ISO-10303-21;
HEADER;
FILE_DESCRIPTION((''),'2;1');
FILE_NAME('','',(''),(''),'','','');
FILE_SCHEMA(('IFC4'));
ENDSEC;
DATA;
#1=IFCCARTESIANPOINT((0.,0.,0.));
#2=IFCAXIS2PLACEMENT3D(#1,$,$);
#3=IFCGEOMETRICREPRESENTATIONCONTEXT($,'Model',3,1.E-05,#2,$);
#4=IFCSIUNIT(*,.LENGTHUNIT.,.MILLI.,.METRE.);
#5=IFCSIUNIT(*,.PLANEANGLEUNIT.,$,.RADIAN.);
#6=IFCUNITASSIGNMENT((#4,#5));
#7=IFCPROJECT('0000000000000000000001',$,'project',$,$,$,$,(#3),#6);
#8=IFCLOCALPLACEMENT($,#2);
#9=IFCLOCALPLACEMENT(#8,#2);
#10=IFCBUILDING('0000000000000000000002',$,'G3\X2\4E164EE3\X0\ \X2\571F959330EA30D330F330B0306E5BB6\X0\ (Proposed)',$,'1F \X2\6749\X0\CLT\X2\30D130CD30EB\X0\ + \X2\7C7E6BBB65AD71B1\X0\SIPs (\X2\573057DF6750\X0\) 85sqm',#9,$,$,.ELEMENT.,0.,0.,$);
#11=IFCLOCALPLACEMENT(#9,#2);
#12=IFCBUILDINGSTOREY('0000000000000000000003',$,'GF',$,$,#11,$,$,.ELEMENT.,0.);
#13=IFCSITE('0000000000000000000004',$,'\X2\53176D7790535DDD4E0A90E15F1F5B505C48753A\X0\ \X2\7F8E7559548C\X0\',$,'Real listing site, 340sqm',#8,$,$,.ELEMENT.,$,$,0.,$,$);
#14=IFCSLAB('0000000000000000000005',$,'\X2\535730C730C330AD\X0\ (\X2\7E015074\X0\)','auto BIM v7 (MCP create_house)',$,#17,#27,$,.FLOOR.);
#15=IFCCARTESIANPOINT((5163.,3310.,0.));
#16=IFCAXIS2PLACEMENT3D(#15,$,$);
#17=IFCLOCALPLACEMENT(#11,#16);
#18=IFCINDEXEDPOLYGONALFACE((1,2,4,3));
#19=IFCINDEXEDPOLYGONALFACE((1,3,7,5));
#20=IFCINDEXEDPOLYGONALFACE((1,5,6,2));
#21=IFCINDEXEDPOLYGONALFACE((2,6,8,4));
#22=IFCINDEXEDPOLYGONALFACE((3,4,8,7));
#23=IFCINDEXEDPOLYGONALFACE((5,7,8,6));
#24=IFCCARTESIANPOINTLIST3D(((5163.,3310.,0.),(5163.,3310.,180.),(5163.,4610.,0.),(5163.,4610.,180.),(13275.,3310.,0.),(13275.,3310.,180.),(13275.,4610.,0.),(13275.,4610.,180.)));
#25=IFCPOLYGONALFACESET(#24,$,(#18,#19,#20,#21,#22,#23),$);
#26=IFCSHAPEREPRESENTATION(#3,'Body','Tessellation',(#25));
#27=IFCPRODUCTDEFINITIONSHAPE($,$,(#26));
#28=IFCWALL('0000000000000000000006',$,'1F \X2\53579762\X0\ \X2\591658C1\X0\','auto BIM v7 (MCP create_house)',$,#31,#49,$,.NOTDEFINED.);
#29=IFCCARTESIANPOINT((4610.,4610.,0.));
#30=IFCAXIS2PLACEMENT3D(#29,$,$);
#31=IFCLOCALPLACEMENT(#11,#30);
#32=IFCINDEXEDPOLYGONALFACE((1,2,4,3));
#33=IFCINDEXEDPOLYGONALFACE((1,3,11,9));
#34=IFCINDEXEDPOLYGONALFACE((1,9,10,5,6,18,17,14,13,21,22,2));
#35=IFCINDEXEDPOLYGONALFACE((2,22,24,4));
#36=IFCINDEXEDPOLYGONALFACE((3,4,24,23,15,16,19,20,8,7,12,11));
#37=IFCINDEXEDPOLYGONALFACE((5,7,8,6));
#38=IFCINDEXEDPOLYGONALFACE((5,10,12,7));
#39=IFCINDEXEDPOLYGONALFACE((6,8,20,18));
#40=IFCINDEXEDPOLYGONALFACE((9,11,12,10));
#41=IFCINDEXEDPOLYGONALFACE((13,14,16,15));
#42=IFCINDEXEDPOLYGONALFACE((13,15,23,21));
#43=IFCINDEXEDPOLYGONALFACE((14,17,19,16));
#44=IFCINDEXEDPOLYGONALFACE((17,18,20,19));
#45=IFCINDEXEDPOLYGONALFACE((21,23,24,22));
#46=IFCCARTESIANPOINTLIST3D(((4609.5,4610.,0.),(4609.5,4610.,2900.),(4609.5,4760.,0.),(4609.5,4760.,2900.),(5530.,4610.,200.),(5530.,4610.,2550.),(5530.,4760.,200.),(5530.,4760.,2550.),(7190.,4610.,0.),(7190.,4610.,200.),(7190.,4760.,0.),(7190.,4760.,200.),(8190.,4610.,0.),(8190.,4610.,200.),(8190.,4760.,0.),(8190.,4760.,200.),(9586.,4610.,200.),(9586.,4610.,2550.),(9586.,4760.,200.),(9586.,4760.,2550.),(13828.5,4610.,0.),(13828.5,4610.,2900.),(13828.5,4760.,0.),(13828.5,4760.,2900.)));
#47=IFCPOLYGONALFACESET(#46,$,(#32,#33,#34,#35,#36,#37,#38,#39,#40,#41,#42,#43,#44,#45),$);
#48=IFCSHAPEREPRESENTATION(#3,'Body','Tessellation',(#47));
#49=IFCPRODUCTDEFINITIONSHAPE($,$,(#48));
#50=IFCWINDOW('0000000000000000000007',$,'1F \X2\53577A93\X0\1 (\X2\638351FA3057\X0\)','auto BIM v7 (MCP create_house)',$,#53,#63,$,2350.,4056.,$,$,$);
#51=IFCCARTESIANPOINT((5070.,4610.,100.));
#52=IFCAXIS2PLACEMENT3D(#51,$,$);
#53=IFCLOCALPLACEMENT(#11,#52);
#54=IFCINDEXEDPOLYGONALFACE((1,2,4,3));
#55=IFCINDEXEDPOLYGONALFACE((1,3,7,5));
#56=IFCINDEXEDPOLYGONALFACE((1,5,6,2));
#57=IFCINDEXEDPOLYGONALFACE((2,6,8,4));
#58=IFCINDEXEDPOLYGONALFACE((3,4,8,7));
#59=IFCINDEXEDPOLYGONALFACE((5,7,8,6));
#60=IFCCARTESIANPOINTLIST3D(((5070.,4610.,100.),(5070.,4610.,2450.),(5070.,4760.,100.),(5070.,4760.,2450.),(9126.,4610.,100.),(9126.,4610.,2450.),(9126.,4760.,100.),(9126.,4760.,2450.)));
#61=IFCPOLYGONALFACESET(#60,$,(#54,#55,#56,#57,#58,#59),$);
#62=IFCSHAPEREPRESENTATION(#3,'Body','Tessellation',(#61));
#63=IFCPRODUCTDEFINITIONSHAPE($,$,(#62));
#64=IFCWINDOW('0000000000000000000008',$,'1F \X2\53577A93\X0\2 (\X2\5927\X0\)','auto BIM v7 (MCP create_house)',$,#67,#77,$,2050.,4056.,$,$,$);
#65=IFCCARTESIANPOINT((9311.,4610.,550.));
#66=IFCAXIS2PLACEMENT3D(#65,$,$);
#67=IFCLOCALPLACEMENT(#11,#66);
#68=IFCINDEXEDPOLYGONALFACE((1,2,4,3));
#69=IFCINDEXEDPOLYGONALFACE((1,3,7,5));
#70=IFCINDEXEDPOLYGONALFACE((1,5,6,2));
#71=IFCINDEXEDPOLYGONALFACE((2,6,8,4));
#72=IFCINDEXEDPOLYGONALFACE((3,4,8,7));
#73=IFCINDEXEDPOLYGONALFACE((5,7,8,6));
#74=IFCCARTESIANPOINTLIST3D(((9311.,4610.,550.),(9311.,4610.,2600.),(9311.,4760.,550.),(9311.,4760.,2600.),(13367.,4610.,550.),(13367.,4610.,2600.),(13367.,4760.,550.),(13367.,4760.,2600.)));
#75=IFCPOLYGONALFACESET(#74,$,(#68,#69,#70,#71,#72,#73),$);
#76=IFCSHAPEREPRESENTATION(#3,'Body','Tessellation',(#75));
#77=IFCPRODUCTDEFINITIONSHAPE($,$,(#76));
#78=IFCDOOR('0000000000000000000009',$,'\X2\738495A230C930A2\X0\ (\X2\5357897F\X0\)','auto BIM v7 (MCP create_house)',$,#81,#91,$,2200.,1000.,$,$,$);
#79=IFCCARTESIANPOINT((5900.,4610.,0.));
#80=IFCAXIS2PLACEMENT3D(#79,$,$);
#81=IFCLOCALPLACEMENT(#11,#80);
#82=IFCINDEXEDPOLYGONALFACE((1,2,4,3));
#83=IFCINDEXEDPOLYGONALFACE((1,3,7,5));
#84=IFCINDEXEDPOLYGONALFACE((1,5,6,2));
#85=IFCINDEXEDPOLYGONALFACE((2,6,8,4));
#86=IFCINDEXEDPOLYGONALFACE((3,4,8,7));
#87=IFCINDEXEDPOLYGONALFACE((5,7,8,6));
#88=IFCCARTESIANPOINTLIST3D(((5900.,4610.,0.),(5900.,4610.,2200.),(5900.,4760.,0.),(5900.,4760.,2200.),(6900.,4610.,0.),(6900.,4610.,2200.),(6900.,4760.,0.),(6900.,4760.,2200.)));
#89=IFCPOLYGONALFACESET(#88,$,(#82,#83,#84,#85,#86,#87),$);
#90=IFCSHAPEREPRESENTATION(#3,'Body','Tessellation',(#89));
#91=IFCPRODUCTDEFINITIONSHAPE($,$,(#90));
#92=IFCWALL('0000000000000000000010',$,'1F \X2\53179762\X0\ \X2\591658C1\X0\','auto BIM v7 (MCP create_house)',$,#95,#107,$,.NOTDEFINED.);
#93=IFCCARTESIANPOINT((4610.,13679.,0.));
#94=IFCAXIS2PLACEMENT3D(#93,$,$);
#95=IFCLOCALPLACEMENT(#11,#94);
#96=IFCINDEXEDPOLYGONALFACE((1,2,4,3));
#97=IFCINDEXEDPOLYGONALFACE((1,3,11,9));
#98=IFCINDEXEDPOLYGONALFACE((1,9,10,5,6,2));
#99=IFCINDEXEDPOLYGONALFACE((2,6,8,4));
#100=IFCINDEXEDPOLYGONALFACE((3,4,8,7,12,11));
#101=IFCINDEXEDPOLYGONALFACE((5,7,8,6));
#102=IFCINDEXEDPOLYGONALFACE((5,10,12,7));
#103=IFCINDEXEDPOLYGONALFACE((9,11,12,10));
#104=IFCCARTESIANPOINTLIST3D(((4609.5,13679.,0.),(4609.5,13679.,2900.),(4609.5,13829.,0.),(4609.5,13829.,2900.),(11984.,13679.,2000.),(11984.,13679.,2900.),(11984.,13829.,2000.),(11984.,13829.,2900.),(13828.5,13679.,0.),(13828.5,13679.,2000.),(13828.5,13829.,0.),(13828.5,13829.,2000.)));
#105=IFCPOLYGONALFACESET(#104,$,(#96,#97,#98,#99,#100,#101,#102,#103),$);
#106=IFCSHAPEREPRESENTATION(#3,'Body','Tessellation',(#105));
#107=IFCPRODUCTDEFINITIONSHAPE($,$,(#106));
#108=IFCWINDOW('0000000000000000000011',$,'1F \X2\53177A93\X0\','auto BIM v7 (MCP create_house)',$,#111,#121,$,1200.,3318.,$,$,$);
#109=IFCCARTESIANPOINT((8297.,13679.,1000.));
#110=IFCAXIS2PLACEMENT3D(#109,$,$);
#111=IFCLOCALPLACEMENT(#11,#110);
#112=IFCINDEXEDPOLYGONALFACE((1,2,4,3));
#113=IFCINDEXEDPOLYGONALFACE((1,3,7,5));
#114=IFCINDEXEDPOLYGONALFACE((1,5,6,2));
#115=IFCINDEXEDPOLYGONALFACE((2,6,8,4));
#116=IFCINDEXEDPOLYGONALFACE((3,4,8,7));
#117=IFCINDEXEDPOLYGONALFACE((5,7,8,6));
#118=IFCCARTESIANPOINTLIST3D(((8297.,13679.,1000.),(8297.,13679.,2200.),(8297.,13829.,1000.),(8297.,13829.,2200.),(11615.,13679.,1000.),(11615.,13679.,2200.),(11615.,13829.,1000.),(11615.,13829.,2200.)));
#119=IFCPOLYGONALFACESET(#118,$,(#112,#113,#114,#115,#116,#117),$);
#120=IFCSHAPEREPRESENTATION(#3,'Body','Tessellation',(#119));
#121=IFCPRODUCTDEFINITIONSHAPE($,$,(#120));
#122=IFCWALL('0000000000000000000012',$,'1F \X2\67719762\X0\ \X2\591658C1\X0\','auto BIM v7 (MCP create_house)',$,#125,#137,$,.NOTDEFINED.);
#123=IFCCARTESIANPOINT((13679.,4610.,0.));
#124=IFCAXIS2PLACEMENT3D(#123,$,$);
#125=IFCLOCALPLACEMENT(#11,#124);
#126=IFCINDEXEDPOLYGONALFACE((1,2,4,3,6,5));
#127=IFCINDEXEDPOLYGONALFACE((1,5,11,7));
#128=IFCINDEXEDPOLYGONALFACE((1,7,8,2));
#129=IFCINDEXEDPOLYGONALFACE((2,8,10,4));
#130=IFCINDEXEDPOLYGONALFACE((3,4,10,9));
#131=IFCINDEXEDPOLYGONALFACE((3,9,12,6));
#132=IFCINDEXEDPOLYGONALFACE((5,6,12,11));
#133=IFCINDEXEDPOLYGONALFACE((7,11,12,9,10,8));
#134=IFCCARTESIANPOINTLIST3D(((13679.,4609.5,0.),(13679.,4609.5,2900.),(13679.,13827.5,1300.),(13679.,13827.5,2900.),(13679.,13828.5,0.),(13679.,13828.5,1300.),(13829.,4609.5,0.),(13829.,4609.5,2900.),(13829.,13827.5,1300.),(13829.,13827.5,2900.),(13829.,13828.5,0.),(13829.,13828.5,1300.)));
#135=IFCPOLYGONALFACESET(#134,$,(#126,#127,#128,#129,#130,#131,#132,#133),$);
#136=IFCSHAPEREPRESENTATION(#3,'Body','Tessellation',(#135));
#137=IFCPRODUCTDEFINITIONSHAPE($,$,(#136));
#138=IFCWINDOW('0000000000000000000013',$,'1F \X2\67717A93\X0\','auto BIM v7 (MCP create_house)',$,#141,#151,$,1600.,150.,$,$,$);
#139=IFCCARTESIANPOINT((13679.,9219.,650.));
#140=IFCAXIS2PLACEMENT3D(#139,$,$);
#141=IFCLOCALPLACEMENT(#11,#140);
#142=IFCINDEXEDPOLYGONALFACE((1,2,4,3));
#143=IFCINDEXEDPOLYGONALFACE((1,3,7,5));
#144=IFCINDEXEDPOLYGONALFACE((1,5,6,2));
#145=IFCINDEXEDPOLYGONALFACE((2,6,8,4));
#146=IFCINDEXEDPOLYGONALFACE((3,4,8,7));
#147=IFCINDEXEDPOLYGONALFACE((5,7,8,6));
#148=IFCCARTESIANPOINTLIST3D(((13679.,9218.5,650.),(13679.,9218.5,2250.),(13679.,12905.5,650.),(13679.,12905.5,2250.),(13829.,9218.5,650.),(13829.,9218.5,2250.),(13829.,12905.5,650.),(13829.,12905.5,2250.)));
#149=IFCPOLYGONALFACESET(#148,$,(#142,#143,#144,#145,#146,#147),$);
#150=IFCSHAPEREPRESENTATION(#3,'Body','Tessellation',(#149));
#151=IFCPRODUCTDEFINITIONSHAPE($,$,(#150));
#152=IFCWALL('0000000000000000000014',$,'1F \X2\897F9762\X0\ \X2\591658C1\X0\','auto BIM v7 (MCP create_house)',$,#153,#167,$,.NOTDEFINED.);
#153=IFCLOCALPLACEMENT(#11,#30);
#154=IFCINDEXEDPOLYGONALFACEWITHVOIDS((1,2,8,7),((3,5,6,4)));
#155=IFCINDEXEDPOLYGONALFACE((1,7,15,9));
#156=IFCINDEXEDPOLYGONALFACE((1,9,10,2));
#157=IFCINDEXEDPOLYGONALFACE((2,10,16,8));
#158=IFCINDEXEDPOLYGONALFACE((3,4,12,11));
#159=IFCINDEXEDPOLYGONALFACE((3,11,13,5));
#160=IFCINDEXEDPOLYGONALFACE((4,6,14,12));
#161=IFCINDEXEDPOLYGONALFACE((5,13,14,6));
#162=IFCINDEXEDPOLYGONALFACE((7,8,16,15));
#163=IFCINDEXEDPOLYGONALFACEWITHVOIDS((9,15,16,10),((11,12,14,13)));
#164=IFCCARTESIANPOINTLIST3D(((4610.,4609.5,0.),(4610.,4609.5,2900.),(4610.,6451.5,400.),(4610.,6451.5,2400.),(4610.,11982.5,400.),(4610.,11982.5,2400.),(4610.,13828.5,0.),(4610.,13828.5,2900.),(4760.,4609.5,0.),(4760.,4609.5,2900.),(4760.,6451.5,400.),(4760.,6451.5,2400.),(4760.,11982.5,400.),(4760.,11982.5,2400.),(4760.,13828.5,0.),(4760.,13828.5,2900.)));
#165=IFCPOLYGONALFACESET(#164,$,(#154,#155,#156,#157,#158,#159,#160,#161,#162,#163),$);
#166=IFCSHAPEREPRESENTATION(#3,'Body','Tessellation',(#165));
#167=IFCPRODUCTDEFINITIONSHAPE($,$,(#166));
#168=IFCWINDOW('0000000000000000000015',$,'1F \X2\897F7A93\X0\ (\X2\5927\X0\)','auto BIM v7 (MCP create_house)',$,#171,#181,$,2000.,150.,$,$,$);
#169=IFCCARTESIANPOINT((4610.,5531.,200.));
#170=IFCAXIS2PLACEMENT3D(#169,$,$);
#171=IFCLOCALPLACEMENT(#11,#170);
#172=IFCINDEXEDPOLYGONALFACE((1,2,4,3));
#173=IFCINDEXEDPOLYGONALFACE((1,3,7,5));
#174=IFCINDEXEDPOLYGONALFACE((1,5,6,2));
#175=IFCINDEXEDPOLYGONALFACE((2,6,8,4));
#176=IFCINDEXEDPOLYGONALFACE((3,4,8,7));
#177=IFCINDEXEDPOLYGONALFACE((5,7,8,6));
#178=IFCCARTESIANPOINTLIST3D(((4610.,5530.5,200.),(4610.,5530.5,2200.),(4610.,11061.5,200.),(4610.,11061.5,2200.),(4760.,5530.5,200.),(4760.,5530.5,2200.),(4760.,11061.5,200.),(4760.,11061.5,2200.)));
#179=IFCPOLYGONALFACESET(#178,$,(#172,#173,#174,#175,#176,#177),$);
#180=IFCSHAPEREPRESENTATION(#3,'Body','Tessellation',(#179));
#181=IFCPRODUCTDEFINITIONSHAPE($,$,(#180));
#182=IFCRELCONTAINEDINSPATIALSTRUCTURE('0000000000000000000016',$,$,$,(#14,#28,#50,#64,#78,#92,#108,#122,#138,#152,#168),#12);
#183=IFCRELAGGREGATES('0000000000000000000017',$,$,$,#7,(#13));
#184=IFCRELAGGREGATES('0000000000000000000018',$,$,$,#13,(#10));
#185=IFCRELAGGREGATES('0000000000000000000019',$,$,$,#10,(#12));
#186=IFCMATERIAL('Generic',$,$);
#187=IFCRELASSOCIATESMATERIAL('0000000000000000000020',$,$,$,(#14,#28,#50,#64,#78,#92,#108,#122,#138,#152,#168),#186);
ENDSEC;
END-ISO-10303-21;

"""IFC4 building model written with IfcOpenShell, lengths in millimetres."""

from ifc_helpers import new_model, si_unit, frame, frame_2d, origin, place, context, project, spatial, rectangle, extrude, material, element, fill, save


model = new_model("IFC4")

# Units and contexts
model_context = context("Model", 3, precision=1e-05, world=origin())
ifc_project = project(units=[si_unit("LENGTHUNIT", "METRE", prefix="MILLI"), si_unit("PLANEANGLEUNIT", "RADIAN")], contexts=[model_context])

# Site, building, storey
site_placement = place(None, origin())
site = spatial("IfcSite", under=ifc_project, at=site_placement, Name="北海道川上郡弟子屈町 美留和", ObjectType="Real listing site, 340sqm", CompositionType="ELEMENT", RefElevation=0.0)
building_placement = place(site_placement, origin())
building = spatial("IfcBuilding", under=site, at=building_placement, Name="G3世代 土間リビングの家 (Proposed)", ObjectType="1F 杉CLTパネル + 籾殻断熱SIPs (地域材) 85sqm", CompositionType="ELEMENT", ElevationOfRefHeight=0.0, ElevationOfTerrain=0.0)
storey_placement = place(building_placement, origin())
storey = spatial("IfcBuildingStorey", under=building, at=storey_placement, Name="GF", CompositionType="ELEMENT", Elevation=0.0)

# Slab
ifc_material = material(Name="Generic")
slab_1_placement = place(storey_placement, frame((5163.0, 3310.0, 0.0)))
element("IfcSlab", 1, at=slab_1_placement, inside=storey, material=ifc_material, Name="南デッキ (縁側)", Description="auto BIM v7 (MCP create_house)", PredefinedType="FLOOR", context=model_context, shape_type="SweptSolid", body=[
    extrude(rectangle(XDim=8112.0, YDim=1300.0, at=frame_2d((4056.0, 650.0))), frame((5163.0, 3310.0, 0.0)), (0.0, 0.0, 1.0), 180.0),
])

# Wall, openings, windows, door
wall_1_placement = place(storey_placement, frame((4610.0, 4610.0, 0.0)))
wall_1 = element("IfcWall", 2, at=wall_1_placement, inside=storey, material=ifc_material, Name="1F 南面 外壁", Description="auto BIM v7 (MCP create_house)", PredefinedType="NOTDEFINED", context=model_context, shape_type="SweptSolid", body=[
    extrude(rectangle(XDim=9219.0, YDim=150.0, at=frame_2d((4609.0, 75.0))), frame((4610.0, 4610.0, 0.0)), (0.0, 0.0, 1.0), 2900.0),
])
opening_1_placement = place(storey_placement, frame((5070.0, 4610.0, 100.0)))
opening_1 = element("IfcOpeningElement", 3, at=opening_1_placement, cuts=wall_1, PredefinedType="NOTDEFINED", context=model_context, shape_type="SweptSolid", body=[
    extrude(rectangle(XDim=4056.0, YDim=150.0, at=frame_2d((2028.0, 75.0))), frame((5070.0, 4610.0, 100.0)), (0.0, 0.0, 1.0), 2350.0),
])
opening_2_placement = place(storey_placement, frame((9311.0, 4610.0, 550.0)))
opening_2 = element("IfcOpeningElement", 4, at=opening_2_placement, cuts=wall_1, PredefinedType="NOTDEFINED", context=model_context, shape_type="SweptSolid", body=[
    extrude(rectangle(XDim=4056.0, YDim=150.0, at=frame_2d((2028.0, 75.0))), frame((9311.0, 4610.0, 550.0)), (0.0, 0.0, 1.0), 2050.0),
])
opening_3_placement = place(storey_placement, frame((5900.0, 4610.0, 0.0)))
opening_3 = element("IfcOpeningElement", 5, at=opening_3_placement, cuts=wall_1, PredefinedType="NOTDEFINED", context=model_context, shape_type="SweptSolid", body=[
    extrude(rectangle(XDim=1000.0, YDim=150.0, at=frame_2d((500.0, 75.0))), frame((5900.0, 4610.0, 0.0)), (0.0, 0.0, 1.0), 2200.0),
])
window_1_placement = place(storey_placement, frame((5070.0, 4610.0, 100.0)))
window_1 = element("IfcWindow", 6, at=window_1_placement, inside=storey, material=ifc_material, Name="1F 南窓1 (掃出し)", Description="auto BIM v7 (MCP create_house)", OverallHeight=2350.0, OverallWidth=4056.0, context=model_context, shape_type="SweptSolid", body=[
    extrude(rectangle(XDim=4056.0, YDim=150.0, at=frame_2d((2028.0, 75.0))), frame((5070.0, 4610.0, 100.0)), (0.0, 0.0, 1.0), 2350.0),
])
fill(opening_1, window_1)
window_2_placement = place(storey_placement, frame((9311.0, 4610.0, 550.0)))
window_2 = element("IfcWindow", 7, at=window_2_placement, inside=storey, material=ifc_material, Name="1F 南窓2 (大)", Description="auto BIM v7 (MCP create_house)", OverallHeight=2050.0, OverallWidth=4056.0, context=model_context, shape_type="SweptSolid", body=[
    extrude(rectangle(XDim=4056.0, YDim=150.0, at=frame_2d((2028.0, 75.0))), frame((9311.0, 4610.0, 550.0)), (0.0, 0.0, 1.0), 2050.0),
])
fill(opening_2, window_2)
door_placement = place(storey_placement, frame((5900.0, 4610.0, 0.0)))
door = element("IfcDoor", 8, at=door_placement, inside=storey, material=ifc_material, Name="玄関ドア (南西)", Description="auto BIM v7 (MCP create_house)", OverallHeight=2200.0, OverallWidth=1000.0, context=model_context, shape_type="SweptSolid", body=[
    extrude(rectangle(XDim=1000.0, YDim=150.0, at=frame_2d((500.0, 75.0))), frame((5900.0, 4610.0, 0.0)), (0.0, 0.0, 1.0), 2200.0),
])
fill(opening_3, door)

# Walls, openings, windows
wall_2_placement = place(storey_placement, frame((4610.0, 13679.0, 0.0)))
wall_2 = element("IfcWall", 9, at=wall_2_placement, inside=storey, material=ifc_material, Name="1F 北面 外壁", Description="auto BIM v7 (MCP create_house)", PredefinedType="NOTDEFINED", context=model_context, shape_type="SweptSolid", body=[
    extrude(rectangle(XDim=9219.0, YDim=150.0, at=frame_2d((4609.0, 75.0))), frame((4610.0, 13679.0, 0.0)), (0.0, 0.0, 1.0), 2900.0),
])
opening_4_placement = place(storey_placement, frame((8297.0, 13679.0, 1000.0)))
opening_4 = element("IfcOpeningElement", 10, at=opening_4_placement, cuts=wall_2, PredefinedType="NOTDEFINED", context=model_context, shape_type="SweptSolid", body=[
    extrude(rectangle(XDim=3318.0, YDim=150.0, at=frame_2d((1659.0, 75.0))), frame((8297.0, 13679.0, 1000.0)), (0.0, 0.0, 1.0), 1200.0),
])
window_3_placement = place(storey_placement, frame((8297.0, 13679.0, 1000.0)))
window_3 = element("IfcWindow", 11, at=window_3_placement, inside=storey, material=ifc_material, Name="1F 北窓", Description="auto BIM v7 (MCP create_house)", OverallHeight=1200.0, OverallWidth=3318.0, context=model_context, shape_type="SweptSolid", body=[
    extrude(rectangle(XDim=3318.0, YDim=150.0, at=frame_2d((1659.0, 75.0))), frame((8297.0, 13679.0, 1000.0)), (0.0, 0.0, 1.0), 1200.0),
])
fill(opening_4, window_3)
wall_3_placement = place(storey_placement, frame((13679.0, 4610.0, 0.0)))
wall_3 = element("IfcWall", 12, at=wall_3_placement, inside=storey, material=ifc_material, Name="1F 東面 外壁", Description="auto BIM v7 (MCP create_house)", PredefinedType="NOTDEFINED", context=model_context, shape_type="SweptSolid", body=[
    extrude(rectangle(XDim=150.0, YDim=9219.0, at=frame_2d((75.0, 4609.0))), frame((13679.0, 4610.0, 0.0)), (0.0, 0.0, 1.0), 2900.0),
])
opening_5_placement = place(storey_placement, frame((13679.0, 9219.0, 650.0)))
opening_5 = element("IfcOpeningElement", 13, at=opening_5_placement, cuts=wall_3, PredefinedType="NOTDEFINED", context=model_context, shape_type="SweptSolid", body=[
    extrude(rectangle(XDim=150.0, YDim=3687.0, at=frame_2d((75.0, 1843.0))), frame((13679.0, 9219.0, 650.0)), (0.0, 0.0, 1.0), 1600.0),
])
window_4_placement = place(storey_placement, frame((13679.0, 9219.0, 650.0)))
window_4 = element("IfcWindow", 14, at=window_4_placement, inside=storey, material=ifc_material, Name="1F 東窓", Description="auto BIM v7 (MCP create_house)", OverallHeight=1600.0, OverallWidth=150.0, context=model_context, shape_type="SweptSolid", body=[
    extrude(rectangle(XDim=150.0, YDim=3687.0, at=frame_2d((75.0, 1843.0))), frame((13679.0, 9219.0, 650.0)), (0.0, 0.0, 1.0), 1600.0),
])
fill(opening_5, window_4)
wall_4_placement = place(storey_placement, frame((4610.0, 4610.0, 0.0)))
wall_4 = element("IfcWall", 15, at=wall_4_placement, inside=storey, material=ifc_material, Name="1F 西面 外壁", Description="auto BIM v7 (MCP create_house)", PredefinedType="NOTDEFINED", context=model_context, shape_type="SweptSolid", body=[
    extrude(rectangle(XDim=150.0, YDim=9219.0, at=frame_2d((75.0, 4609.0))), frame((4610.0, 4610.0, 0.0)), (0.0, 0.0, 1.0), 2900.0),
])
opening_6_placement = place(storey_placement, frame((4610.0, 5531.0, 200.0)))
opening_6 = element("IfcOpeningElement", 16, at=opening_6_placement, cuts=wall_4, PredefinedType="NOTDEFINED", context=model_context, shape_type="SweptSolid", body=[
    extrude(rectangle(XDim=150.0, YDim=5531.0, at=frame_2d((75.0, 2765.0))), frame((4610.0, 5531.0, 200.0)), (0.0, 0.0, 1.0), 2000.0),
])
window_5_placement = place(storey_placement, frame((4610.0, 5531.0, 200.0)))
window_5 = element("IfcWindow", 17, at=window_5_placement, inside=storey, material=ifc_material, Name="1F 西窓 (大)", Description="auto BIM v7 (MCP create_house)", OverallHeight=2000.0, OverallWidth=150.0, context=model_context, shape_type="SweptSolid", body=[
    extrude(rectangle(XDim=150.0, YDim=5531.0, at=frame_2d((75.0, 2765.0))), frame((4610.0, 5531.0, 200.0)), (0.0, 0.0, 1.0), 2000.0),
])
fill(opening_6, window_5)

save(model, "model.ifc")
